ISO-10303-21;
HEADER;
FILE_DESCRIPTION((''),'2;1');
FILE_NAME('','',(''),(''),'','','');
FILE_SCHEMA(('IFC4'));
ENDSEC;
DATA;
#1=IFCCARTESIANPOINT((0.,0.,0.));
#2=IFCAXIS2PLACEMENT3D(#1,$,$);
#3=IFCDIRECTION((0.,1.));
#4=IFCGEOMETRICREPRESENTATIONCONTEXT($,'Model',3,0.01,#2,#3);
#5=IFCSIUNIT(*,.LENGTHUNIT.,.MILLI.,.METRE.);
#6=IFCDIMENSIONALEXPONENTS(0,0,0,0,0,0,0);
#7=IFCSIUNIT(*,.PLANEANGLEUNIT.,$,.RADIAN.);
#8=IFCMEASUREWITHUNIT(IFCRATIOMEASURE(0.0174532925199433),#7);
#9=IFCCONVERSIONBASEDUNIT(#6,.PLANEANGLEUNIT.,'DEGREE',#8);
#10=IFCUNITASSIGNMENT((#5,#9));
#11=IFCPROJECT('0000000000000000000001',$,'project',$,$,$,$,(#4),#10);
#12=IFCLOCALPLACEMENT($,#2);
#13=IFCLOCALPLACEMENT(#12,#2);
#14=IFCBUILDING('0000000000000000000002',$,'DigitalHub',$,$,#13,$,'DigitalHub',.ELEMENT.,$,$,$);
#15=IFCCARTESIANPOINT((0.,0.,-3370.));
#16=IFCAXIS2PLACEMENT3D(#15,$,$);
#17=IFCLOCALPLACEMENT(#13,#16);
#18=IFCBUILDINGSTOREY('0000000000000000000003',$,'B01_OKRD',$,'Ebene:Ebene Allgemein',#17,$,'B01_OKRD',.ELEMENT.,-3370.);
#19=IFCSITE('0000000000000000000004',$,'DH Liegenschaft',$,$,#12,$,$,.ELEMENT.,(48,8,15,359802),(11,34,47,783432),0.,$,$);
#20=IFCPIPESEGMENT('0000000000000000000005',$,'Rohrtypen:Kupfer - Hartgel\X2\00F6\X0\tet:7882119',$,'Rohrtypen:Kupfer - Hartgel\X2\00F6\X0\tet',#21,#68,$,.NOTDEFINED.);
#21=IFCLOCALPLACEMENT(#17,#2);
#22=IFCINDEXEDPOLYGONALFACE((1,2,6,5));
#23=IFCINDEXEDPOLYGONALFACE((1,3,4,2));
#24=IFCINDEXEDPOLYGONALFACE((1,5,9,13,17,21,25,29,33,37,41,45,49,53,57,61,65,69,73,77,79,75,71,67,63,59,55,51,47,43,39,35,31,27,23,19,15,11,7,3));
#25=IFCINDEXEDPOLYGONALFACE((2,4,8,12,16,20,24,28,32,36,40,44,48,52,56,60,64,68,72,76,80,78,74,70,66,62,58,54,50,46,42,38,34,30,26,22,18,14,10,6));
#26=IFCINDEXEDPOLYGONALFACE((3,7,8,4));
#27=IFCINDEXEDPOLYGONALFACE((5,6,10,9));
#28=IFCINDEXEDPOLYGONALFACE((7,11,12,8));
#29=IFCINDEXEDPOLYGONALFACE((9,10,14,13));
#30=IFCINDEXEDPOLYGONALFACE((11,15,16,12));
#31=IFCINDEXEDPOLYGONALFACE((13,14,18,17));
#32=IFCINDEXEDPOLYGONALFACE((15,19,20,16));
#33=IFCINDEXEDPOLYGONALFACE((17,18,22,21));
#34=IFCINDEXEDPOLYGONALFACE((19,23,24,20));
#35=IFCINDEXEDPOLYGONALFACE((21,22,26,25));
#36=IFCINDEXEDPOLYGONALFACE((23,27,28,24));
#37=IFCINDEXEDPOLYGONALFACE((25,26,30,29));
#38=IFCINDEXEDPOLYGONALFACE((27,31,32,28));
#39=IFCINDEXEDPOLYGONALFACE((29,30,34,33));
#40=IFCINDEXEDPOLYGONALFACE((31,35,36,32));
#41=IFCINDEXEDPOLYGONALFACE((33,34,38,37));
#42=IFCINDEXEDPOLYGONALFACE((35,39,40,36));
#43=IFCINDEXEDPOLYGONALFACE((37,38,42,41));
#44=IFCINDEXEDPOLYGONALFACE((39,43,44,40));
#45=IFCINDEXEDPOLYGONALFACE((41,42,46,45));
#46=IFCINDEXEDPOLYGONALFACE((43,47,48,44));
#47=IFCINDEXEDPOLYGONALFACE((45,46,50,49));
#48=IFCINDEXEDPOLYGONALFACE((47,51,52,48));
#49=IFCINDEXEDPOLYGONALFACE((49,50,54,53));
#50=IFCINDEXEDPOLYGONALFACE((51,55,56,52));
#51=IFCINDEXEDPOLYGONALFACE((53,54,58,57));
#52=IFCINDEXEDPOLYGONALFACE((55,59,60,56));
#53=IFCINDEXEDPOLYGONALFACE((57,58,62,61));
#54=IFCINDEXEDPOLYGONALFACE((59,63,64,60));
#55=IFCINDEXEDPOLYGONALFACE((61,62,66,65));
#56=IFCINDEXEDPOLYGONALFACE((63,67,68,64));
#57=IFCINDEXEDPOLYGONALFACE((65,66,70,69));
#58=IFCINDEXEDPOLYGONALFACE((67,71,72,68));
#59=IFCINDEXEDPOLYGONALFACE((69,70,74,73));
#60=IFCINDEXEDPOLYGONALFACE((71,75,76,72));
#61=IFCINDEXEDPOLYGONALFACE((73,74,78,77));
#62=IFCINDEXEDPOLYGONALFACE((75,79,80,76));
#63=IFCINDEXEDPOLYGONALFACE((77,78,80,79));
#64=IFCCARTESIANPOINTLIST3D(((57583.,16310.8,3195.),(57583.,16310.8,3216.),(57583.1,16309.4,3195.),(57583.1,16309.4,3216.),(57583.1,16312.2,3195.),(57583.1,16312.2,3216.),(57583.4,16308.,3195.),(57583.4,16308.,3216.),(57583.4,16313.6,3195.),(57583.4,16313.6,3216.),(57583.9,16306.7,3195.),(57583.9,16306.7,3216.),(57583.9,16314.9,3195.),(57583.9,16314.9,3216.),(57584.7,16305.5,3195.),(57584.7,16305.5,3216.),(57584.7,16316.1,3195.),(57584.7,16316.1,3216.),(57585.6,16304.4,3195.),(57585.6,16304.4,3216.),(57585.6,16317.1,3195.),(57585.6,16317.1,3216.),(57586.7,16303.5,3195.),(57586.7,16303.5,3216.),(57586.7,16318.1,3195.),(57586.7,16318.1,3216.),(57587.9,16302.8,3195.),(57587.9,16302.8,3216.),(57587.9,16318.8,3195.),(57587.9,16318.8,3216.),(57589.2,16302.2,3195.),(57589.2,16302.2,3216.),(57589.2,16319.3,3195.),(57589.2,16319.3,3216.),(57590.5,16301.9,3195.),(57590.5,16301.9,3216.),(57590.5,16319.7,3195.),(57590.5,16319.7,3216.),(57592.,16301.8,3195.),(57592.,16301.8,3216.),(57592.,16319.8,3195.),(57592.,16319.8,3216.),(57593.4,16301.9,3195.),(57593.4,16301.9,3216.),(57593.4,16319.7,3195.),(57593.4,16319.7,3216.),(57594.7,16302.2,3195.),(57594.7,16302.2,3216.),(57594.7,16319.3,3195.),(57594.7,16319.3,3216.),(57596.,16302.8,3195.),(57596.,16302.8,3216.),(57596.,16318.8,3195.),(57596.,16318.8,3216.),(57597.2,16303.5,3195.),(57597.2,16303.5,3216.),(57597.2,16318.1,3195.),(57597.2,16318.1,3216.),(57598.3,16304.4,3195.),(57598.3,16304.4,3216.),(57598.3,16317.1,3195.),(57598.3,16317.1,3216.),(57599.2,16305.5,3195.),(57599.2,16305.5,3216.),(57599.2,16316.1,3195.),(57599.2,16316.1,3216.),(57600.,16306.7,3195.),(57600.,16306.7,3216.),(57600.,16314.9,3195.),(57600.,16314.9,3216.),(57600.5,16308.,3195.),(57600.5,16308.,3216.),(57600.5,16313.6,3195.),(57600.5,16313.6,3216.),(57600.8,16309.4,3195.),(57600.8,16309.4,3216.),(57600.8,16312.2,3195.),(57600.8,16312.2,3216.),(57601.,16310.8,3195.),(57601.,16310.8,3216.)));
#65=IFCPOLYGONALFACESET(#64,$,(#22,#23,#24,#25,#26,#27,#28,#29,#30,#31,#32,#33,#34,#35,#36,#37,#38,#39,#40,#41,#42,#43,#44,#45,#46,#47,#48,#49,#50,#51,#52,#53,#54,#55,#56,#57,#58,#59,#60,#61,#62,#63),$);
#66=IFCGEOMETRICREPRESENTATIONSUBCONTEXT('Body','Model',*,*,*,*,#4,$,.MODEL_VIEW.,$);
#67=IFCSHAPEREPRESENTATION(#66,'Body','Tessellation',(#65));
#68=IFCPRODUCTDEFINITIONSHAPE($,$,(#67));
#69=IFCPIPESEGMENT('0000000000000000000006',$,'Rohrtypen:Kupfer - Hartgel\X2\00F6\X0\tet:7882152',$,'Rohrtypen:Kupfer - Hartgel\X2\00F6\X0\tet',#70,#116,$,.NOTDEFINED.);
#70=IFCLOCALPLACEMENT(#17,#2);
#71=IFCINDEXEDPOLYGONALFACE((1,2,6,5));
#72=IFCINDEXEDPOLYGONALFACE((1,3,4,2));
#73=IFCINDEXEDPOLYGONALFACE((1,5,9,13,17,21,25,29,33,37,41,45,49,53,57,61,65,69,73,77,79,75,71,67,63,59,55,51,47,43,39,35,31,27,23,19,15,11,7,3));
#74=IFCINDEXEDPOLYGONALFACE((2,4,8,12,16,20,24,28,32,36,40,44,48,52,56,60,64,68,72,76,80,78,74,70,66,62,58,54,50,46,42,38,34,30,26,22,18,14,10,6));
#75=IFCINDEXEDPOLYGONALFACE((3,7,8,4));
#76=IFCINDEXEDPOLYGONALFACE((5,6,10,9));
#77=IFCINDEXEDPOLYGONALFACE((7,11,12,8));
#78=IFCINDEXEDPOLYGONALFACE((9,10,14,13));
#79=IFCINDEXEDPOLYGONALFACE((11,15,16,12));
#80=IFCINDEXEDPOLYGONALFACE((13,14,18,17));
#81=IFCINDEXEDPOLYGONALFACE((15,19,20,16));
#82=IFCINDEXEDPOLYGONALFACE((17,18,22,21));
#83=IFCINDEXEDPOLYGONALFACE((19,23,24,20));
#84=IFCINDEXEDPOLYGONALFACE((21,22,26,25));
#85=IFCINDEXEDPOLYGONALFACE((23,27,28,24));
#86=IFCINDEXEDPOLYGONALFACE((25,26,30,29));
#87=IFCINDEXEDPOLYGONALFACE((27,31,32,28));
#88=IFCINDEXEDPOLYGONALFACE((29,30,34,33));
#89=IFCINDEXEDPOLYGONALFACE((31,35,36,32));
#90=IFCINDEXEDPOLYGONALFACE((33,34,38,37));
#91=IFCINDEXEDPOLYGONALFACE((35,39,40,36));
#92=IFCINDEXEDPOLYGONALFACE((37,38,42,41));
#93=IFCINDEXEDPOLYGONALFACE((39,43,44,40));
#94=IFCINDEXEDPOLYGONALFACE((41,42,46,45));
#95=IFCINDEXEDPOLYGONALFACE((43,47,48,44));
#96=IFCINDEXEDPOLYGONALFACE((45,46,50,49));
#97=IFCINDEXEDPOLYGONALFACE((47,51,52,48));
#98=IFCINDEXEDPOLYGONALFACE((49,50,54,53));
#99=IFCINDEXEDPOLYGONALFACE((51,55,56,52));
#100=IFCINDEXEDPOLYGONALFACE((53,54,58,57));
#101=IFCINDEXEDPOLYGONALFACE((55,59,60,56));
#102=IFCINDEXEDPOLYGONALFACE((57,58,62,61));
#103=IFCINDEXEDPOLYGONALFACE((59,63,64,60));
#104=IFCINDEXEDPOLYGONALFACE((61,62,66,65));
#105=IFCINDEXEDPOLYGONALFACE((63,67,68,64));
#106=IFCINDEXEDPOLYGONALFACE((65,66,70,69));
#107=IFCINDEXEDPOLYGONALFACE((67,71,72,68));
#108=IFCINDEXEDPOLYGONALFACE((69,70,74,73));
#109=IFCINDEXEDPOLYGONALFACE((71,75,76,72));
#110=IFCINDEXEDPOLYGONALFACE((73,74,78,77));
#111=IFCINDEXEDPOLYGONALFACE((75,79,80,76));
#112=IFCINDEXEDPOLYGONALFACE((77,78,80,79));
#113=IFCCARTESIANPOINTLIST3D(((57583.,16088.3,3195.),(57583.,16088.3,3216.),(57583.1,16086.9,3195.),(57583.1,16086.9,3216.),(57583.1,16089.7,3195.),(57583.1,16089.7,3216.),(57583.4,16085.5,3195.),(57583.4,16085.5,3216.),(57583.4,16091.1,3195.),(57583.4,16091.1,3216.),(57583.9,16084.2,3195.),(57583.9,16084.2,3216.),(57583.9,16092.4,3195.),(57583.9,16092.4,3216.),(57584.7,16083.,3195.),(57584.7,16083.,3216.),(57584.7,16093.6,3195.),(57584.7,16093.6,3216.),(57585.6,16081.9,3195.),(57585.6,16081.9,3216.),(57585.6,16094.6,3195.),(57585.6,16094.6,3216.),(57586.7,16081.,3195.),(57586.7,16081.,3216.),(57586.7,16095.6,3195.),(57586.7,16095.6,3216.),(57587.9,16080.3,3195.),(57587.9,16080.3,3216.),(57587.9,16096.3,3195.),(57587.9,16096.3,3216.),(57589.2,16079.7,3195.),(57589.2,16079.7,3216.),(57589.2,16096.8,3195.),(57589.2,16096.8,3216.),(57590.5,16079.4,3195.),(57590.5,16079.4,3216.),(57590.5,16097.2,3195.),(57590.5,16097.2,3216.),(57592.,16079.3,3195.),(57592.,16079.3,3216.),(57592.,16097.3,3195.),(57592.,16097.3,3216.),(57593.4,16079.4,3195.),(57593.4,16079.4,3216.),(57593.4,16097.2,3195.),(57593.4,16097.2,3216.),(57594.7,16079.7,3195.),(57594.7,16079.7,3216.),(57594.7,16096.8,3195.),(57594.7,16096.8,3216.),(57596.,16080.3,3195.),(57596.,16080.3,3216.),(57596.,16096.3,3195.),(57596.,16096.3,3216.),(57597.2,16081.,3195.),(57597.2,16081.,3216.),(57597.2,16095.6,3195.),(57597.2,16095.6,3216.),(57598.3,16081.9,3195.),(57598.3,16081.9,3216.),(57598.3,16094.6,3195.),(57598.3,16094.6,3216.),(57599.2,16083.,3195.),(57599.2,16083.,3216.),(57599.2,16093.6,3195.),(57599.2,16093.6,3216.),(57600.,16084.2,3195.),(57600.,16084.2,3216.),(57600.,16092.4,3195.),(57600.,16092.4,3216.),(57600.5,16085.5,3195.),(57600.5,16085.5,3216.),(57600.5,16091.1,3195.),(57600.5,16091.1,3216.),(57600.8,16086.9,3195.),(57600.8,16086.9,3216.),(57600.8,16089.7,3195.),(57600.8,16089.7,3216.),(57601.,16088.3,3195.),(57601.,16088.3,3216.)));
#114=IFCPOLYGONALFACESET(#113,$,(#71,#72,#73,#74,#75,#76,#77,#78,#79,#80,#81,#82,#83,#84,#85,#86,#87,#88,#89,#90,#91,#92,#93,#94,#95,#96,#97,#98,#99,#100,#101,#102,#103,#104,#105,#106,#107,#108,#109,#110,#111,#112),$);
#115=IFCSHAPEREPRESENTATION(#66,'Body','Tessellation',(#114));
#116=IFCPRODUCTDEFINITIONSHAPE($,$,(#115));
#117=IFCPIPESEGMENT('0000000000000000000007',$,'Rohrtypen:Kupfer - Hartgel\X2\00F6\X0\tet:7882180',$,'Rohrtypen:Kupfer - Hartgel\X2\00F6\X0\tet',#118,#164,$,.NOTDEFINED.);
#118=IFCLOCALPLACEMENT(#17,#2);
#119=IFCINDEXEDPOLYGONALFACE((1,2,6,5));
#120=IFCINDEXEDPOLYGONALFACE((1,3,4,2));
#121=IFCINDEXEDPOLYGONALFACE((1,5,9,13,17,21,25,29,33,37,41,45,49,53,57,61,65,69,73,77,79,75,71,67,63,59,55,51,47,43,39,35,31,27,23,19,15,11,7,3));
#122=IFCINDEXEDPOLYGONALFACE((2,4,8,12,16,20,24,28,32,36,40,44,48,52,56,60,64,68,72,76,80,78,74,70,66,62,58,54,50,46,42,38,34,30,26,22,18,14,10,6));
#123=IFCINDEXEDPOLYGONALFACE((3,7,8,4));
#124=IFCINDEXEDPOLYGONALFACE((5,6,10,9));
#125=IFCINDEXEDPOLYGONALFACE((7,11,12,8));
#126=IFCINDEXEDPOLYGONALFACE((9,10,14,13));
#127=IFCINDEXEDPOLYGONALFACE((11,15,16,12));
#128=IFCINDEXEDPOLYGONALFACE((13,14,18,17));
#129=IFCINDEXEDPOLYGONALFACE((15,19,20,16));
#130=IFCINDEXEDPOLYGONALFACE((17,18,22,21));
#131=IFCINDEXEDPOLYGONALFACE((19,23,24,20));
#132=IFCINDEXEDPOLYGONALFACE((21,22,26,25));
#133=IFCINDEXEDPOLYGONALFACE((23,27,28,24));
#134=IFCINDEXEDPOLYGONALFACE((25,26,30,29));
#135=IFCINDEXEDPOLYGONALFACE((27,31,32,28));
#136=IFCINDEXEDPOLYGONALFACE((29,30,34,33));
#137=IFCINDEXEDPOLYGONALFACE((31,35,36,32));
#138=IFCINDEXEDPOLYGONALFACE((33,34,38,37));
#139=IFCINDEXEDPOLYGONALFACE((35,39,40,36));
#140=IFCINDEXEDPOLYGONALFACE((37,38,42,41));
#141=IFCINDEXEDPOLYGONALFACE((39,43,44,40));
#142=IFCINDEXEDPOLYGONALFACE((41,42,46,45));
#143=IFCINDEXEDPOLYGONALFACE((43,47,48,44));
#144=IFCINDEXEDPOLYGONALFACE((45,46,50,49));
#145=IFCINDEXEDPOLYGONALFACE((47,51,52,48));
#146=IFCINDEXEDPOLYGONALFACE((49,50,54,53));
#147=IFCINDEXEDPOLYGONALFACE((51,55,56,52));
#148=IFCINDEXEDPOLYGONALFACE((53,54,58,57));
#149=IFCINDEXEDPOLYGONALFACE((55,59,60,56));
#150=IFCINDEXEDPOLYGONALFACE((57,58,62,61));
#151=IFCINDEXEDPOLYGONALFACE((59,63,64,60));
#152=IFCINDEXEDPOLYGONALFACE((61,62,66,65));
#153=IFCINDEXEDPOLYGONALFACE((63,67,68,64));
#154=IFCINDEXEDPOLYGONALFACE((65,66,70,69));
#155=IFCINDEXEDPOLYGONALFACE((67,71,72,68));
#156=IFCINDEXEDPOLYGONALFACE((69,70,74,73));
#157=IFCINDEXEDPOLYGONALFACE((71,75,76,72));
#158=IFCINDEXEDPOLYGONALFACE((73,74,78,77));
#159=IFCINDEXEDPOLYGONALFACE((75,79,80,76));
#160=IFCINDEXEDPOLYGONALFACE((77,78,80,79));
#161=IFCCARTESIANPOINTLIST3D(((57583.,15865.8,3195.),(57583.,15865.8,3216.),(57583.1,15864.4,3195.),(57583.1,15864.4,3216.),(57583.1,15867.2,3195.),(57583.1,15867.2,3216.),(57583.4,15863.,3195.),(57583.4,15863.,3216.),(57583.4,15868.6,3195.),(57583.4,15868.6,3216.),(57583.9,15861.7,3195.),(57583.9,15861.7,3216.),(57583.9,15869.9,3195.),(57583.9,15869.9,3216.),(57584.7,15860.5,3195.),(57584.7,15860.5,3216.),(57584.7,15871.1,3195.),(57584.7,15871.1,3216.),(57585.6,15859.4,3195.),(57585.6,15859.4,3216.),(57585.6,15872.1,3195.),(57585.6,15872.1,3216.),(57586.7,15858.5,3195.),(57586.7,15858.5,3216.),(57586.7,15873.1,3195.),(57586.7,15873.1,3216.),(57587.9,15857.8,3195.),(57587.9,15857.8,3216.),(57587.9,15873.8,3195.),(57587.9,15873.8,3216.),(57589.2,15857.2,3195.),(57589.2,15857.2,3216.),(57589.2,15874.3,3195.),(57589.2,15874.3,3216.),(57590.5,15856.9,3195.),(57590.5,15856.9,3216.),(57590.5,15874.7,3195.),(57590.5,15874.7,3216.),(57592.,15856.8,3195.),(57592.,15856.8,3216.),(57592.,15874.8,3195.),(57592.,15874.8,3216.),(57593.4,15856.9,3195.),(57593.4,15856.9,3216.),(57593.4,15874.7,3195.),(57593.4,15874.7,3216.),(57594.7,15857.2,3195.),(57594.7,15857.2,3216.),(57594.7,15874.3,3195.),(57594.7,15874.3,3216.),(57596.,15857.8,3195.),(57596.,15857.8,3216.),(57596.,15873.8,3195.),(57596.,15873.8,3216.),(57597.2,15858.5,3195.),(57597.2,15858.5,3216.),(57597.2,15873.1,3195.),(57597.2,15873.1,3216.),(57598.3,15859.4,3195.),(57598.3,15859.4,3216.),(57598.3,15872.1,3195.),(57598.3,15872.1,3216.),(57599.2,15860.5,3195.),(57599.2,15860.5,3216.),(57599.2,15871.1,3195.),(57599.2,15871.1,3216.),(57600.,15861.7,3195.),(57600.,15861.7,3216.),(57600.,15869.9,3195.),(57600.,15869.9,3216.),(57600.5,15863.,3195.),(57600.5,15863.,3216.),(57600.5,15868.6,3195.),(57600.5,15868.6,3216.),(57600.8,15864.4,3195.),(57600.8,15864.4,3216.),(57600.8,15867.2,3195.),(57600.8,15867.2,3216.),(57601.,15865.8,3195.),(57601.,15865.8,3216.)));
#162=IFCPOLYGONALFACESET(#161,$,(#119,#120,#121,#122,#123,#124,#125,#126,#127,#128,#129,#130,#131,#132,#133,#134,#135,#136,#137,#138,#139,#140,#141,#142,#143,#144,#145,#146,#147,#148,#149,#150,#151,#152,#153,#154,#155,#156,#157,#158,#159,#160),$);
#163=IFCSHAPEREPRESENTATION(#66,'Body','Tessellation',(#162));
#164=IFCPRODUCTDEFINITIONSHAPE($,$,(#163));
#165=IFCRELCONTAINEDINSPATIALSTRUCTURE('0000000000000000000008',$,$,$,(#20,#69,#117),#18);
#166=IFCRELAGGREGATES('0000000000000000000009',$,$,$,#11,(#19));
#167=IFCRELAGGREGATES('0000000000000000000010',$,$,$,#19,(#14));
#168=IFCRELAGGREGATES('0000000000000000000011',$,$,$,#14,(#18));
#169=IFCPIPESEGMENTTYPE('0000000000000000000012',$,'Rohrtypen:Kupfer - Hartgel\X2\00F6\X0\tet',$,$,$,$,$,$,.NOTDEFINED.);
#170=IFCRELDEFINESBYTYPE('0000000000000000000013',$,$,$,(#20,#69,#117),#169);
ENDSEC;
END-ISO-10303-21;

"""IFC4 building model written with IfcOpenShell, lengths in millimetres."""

from ifc_helpers import new_model, entity, si_unit, converted_unit, direction, frame, origin, place, context, subcontext, project, spatial, indexed_curve, outline, extrude, type_object, element, save


model = new_model("IFC4")

# Units and contexts
model_context = context("Model", 3, precision=0.01, world=origin(), true_north=direction((0.0, 1.0)))
body_context = subcontext(model_context, "Body", "Model", "MODEL_VIEW")
ifc_project = project(units=[si_unit("LENGTHUNIT", "METRE", prefix="MILLI"), converted_unit("PLANEANGLEUNIT", "DEGREE", entity("IfcRatioMeasure", 0.0174532925199433), si_unit("PLANEANGLEUNIT", "RADIAN"), dimensions=[0, 0, 0, 0, 0, 0, 0])], contexts=[model_context])

# Site, building, storey
site_placement = place(None, origin())
site = spatial("IfcSite", under=ifc_project, at=site_placement, Name="DH Liegenschaft", CompositionType="ELEMENT", RefLatitude=(48, 8, 15, 359802), RefLongitude=(11, 34, 47, 783432), RefElevation=0.0)
building_placement = place(site_placement, origin())
building = spatial("IfcBuilding", under=site, at=building_placement, Name="DigitalHub", LongName="DigitalHub", CompositionType="ELEMENT")
storey_placement = place(building_placement, frame((0.0, 0.0, -3370.0)))
storey = spatial("IfcBuildingStorey", under=building, at=storey_placement, Name="B01_OKRD", ObjectType="Ebene:Ebene Allgemein", LongName="B01_OKRD", CompositionType="ELEMENT", Elevation=-3370.0)

# Pipe segments
pipe_segment_type = type_object("IfcPipeSegmentType", Name="Rohrtypen:Kupfer - Hartgelötet", PredefinedType="NOTDEFINED")
pipe_segment_1_placement = place(storey_placement, frame((57581.4, 16300.2, 3195.0)))
element("IfcPipeSegment", 1, at=pipe_segment_1_placement, inside=storey, type_object=pipe_segment_type, Name="Rohrtypen:Kupfer - Hartgelötet:7882119", ObjectType="Rohrtypen:Kupfer - Hartgelötet", PredefinedType="NOTDEFINED", context=body_context, shape_type="SweptSolid", body=[
    extrude(outline(indexed_curve([(9.0, 0.0), (8.9, 1.4), (8.6, 2.8), (8.0, 4.1), (7.3, 5.3), (6.4, 6.4), (5.3, 7.3), (4.1, 8.0), (2.8, 8.6), (1.4, 8.9), (0.0, 9.0), (-1.4, 8.9), (-2.8, 8.6), (-4.1, 8.0), (-5.3, 7.3), (-6.4, 6.4), (-7.3, 5.3), (-8.0, 4.1), (-8.6, 2.8), (-8.9, 1.4), (-9.0, 0.0), (-8.9, -1.4), (-8.6, -2.8), (-8.0, -4.1), (-7.3, -5.3), (-6.4, -6.4), (-5.3, -7.3), (-4.1, -8.0), (-2.8, -8.6), (-1.4, -8.9), (0.0, -9.0), (1.4, -8.9), (2.8, -8.6), (4.1, -8.0), (5.3, -7.3), (6.4, -6.4), (7.3, -5.3), (8.0, -4.1), (8.6, -2.8), (8.9, -1.4), (9.0, 0.0)], self_intersect=False)), frame((10.6, 10.6, 0.0)), (0.0, 0.0, 1.0), 21.0),
])
pipe_segment_2_placement = place(storey_placement, frame((57581.4, 16077.7, 3195.0)))
element("IfcPipeSegment", 2, at=pipe_segment_2_placement, inside=storey, type_object=pipe_segment_type, Name="Rohrtypen:Kupfer - Hartgelötet:7882152", ObjectType="Rohrtypen:Kupfer - Hartgelötet", PredefinedType="NOTDEFINED", context=body_context, shape_type="SweptSolid", body=[
    extrude(outline(indexed_curve([(9.0, 0.0), (8.9, 1.4), (8.6, 2.8), (8.0, 4.1), (7.3, 5.3), (6.4, 6.4), (5.3, 7.3), (4.1, 8.0), (2.8, 8.6), (1.4, 8.9), (0.0, 9.0), (-1.4, 8.9), (-2.8, 8.6), (-4.1, 8.0), (-5.3, 7.3), (-6.4, 6.4), (-7.3, 5.3), (-8.0, 4.1), (-8.6, 2.8), (-8.9, 1.4), (-9.0, 0.0), (-8.9, -1.4), (-8.6, -2.8), (-8.0, -4.1), (-7.3, -5.3), (-6.4, -6.4), (-5.3, -7.3), (-4.1, -8.0), (-2.8, -8.6), (-1.4, -8.9), (0.0, -9.0), (1.4, -8.9), (2.8, -8.6), (4.1, -8.0), (5.3, -7.3), (6.4, -6.4), (7.3, -5.3), (8.0, -4.1), (8.6, -2.8), (8.9, -1.4), (9.0, 0.0)], self_intersect=False)), frame((10.6, 10.6, 0.0)), (0.0, 0.0, 1.0), 21.0),
])
pipe_segment_3_placement = place(storey_placement, frame((57581.4, 15855.2, 3195.0)))
element("IfcPipeSegment", 3, at=pipe_segment_3_placement, inside=storey, type_object=pipe_segment_type, Name="Rohrtypen:Kupfer - Hartgelötet:7882180", ObjectType="Rohrtypen:Kupfer - Hartgelötet", PredefinedType="NOTDEFINED", context=body_context, shape_type="SweptSolid", body=[
    extrude(outline(indexed_curve([(9.0, 0.0), (8.9, 1.4), (8.6, 2.8), (8.0, 4.1), (7.3, 5.3), (6.4, 6.4), (5.3, 7.3), (4.1, 8.0), (2.8, 8.6), (1.4, 8.9), (0.0, 9.0), (-1.4, 8.9), (-2.8, 8.6), (-4.1, 8.0), (-5.3, 7.3), (-6.4, 6.4), (-7.3, 5.3), (-8.0, 4.1), (-8.6, 2.8), (-8.9, 1.4), (-9.0, 0.0), (-8.9, -1.4), (-8.6, -2.8), (-8.0, -4.1), (-7.3, -5.3), (-6.4, -6.4), (-5.3, -7.3), (-4.1, -8.0), (-2.8, -8.6), (-1.4, -8.9), (0.0, -9.0), (1.4, -8.9), (2.8, -8.6), (4.1, -8.0), (5.3, -7.3), (6.4, -6.4), (7.3, -5.3), (8.0, -4.1), (8.6, -2.8), (8.9, -1.4), (9.0, 0.0)], self_intersect=False)), frame((10.6, 10.6, 0.0)), (0.0, 0.0, 1.0), 21.0),
])

save(model, "model.ifc")
